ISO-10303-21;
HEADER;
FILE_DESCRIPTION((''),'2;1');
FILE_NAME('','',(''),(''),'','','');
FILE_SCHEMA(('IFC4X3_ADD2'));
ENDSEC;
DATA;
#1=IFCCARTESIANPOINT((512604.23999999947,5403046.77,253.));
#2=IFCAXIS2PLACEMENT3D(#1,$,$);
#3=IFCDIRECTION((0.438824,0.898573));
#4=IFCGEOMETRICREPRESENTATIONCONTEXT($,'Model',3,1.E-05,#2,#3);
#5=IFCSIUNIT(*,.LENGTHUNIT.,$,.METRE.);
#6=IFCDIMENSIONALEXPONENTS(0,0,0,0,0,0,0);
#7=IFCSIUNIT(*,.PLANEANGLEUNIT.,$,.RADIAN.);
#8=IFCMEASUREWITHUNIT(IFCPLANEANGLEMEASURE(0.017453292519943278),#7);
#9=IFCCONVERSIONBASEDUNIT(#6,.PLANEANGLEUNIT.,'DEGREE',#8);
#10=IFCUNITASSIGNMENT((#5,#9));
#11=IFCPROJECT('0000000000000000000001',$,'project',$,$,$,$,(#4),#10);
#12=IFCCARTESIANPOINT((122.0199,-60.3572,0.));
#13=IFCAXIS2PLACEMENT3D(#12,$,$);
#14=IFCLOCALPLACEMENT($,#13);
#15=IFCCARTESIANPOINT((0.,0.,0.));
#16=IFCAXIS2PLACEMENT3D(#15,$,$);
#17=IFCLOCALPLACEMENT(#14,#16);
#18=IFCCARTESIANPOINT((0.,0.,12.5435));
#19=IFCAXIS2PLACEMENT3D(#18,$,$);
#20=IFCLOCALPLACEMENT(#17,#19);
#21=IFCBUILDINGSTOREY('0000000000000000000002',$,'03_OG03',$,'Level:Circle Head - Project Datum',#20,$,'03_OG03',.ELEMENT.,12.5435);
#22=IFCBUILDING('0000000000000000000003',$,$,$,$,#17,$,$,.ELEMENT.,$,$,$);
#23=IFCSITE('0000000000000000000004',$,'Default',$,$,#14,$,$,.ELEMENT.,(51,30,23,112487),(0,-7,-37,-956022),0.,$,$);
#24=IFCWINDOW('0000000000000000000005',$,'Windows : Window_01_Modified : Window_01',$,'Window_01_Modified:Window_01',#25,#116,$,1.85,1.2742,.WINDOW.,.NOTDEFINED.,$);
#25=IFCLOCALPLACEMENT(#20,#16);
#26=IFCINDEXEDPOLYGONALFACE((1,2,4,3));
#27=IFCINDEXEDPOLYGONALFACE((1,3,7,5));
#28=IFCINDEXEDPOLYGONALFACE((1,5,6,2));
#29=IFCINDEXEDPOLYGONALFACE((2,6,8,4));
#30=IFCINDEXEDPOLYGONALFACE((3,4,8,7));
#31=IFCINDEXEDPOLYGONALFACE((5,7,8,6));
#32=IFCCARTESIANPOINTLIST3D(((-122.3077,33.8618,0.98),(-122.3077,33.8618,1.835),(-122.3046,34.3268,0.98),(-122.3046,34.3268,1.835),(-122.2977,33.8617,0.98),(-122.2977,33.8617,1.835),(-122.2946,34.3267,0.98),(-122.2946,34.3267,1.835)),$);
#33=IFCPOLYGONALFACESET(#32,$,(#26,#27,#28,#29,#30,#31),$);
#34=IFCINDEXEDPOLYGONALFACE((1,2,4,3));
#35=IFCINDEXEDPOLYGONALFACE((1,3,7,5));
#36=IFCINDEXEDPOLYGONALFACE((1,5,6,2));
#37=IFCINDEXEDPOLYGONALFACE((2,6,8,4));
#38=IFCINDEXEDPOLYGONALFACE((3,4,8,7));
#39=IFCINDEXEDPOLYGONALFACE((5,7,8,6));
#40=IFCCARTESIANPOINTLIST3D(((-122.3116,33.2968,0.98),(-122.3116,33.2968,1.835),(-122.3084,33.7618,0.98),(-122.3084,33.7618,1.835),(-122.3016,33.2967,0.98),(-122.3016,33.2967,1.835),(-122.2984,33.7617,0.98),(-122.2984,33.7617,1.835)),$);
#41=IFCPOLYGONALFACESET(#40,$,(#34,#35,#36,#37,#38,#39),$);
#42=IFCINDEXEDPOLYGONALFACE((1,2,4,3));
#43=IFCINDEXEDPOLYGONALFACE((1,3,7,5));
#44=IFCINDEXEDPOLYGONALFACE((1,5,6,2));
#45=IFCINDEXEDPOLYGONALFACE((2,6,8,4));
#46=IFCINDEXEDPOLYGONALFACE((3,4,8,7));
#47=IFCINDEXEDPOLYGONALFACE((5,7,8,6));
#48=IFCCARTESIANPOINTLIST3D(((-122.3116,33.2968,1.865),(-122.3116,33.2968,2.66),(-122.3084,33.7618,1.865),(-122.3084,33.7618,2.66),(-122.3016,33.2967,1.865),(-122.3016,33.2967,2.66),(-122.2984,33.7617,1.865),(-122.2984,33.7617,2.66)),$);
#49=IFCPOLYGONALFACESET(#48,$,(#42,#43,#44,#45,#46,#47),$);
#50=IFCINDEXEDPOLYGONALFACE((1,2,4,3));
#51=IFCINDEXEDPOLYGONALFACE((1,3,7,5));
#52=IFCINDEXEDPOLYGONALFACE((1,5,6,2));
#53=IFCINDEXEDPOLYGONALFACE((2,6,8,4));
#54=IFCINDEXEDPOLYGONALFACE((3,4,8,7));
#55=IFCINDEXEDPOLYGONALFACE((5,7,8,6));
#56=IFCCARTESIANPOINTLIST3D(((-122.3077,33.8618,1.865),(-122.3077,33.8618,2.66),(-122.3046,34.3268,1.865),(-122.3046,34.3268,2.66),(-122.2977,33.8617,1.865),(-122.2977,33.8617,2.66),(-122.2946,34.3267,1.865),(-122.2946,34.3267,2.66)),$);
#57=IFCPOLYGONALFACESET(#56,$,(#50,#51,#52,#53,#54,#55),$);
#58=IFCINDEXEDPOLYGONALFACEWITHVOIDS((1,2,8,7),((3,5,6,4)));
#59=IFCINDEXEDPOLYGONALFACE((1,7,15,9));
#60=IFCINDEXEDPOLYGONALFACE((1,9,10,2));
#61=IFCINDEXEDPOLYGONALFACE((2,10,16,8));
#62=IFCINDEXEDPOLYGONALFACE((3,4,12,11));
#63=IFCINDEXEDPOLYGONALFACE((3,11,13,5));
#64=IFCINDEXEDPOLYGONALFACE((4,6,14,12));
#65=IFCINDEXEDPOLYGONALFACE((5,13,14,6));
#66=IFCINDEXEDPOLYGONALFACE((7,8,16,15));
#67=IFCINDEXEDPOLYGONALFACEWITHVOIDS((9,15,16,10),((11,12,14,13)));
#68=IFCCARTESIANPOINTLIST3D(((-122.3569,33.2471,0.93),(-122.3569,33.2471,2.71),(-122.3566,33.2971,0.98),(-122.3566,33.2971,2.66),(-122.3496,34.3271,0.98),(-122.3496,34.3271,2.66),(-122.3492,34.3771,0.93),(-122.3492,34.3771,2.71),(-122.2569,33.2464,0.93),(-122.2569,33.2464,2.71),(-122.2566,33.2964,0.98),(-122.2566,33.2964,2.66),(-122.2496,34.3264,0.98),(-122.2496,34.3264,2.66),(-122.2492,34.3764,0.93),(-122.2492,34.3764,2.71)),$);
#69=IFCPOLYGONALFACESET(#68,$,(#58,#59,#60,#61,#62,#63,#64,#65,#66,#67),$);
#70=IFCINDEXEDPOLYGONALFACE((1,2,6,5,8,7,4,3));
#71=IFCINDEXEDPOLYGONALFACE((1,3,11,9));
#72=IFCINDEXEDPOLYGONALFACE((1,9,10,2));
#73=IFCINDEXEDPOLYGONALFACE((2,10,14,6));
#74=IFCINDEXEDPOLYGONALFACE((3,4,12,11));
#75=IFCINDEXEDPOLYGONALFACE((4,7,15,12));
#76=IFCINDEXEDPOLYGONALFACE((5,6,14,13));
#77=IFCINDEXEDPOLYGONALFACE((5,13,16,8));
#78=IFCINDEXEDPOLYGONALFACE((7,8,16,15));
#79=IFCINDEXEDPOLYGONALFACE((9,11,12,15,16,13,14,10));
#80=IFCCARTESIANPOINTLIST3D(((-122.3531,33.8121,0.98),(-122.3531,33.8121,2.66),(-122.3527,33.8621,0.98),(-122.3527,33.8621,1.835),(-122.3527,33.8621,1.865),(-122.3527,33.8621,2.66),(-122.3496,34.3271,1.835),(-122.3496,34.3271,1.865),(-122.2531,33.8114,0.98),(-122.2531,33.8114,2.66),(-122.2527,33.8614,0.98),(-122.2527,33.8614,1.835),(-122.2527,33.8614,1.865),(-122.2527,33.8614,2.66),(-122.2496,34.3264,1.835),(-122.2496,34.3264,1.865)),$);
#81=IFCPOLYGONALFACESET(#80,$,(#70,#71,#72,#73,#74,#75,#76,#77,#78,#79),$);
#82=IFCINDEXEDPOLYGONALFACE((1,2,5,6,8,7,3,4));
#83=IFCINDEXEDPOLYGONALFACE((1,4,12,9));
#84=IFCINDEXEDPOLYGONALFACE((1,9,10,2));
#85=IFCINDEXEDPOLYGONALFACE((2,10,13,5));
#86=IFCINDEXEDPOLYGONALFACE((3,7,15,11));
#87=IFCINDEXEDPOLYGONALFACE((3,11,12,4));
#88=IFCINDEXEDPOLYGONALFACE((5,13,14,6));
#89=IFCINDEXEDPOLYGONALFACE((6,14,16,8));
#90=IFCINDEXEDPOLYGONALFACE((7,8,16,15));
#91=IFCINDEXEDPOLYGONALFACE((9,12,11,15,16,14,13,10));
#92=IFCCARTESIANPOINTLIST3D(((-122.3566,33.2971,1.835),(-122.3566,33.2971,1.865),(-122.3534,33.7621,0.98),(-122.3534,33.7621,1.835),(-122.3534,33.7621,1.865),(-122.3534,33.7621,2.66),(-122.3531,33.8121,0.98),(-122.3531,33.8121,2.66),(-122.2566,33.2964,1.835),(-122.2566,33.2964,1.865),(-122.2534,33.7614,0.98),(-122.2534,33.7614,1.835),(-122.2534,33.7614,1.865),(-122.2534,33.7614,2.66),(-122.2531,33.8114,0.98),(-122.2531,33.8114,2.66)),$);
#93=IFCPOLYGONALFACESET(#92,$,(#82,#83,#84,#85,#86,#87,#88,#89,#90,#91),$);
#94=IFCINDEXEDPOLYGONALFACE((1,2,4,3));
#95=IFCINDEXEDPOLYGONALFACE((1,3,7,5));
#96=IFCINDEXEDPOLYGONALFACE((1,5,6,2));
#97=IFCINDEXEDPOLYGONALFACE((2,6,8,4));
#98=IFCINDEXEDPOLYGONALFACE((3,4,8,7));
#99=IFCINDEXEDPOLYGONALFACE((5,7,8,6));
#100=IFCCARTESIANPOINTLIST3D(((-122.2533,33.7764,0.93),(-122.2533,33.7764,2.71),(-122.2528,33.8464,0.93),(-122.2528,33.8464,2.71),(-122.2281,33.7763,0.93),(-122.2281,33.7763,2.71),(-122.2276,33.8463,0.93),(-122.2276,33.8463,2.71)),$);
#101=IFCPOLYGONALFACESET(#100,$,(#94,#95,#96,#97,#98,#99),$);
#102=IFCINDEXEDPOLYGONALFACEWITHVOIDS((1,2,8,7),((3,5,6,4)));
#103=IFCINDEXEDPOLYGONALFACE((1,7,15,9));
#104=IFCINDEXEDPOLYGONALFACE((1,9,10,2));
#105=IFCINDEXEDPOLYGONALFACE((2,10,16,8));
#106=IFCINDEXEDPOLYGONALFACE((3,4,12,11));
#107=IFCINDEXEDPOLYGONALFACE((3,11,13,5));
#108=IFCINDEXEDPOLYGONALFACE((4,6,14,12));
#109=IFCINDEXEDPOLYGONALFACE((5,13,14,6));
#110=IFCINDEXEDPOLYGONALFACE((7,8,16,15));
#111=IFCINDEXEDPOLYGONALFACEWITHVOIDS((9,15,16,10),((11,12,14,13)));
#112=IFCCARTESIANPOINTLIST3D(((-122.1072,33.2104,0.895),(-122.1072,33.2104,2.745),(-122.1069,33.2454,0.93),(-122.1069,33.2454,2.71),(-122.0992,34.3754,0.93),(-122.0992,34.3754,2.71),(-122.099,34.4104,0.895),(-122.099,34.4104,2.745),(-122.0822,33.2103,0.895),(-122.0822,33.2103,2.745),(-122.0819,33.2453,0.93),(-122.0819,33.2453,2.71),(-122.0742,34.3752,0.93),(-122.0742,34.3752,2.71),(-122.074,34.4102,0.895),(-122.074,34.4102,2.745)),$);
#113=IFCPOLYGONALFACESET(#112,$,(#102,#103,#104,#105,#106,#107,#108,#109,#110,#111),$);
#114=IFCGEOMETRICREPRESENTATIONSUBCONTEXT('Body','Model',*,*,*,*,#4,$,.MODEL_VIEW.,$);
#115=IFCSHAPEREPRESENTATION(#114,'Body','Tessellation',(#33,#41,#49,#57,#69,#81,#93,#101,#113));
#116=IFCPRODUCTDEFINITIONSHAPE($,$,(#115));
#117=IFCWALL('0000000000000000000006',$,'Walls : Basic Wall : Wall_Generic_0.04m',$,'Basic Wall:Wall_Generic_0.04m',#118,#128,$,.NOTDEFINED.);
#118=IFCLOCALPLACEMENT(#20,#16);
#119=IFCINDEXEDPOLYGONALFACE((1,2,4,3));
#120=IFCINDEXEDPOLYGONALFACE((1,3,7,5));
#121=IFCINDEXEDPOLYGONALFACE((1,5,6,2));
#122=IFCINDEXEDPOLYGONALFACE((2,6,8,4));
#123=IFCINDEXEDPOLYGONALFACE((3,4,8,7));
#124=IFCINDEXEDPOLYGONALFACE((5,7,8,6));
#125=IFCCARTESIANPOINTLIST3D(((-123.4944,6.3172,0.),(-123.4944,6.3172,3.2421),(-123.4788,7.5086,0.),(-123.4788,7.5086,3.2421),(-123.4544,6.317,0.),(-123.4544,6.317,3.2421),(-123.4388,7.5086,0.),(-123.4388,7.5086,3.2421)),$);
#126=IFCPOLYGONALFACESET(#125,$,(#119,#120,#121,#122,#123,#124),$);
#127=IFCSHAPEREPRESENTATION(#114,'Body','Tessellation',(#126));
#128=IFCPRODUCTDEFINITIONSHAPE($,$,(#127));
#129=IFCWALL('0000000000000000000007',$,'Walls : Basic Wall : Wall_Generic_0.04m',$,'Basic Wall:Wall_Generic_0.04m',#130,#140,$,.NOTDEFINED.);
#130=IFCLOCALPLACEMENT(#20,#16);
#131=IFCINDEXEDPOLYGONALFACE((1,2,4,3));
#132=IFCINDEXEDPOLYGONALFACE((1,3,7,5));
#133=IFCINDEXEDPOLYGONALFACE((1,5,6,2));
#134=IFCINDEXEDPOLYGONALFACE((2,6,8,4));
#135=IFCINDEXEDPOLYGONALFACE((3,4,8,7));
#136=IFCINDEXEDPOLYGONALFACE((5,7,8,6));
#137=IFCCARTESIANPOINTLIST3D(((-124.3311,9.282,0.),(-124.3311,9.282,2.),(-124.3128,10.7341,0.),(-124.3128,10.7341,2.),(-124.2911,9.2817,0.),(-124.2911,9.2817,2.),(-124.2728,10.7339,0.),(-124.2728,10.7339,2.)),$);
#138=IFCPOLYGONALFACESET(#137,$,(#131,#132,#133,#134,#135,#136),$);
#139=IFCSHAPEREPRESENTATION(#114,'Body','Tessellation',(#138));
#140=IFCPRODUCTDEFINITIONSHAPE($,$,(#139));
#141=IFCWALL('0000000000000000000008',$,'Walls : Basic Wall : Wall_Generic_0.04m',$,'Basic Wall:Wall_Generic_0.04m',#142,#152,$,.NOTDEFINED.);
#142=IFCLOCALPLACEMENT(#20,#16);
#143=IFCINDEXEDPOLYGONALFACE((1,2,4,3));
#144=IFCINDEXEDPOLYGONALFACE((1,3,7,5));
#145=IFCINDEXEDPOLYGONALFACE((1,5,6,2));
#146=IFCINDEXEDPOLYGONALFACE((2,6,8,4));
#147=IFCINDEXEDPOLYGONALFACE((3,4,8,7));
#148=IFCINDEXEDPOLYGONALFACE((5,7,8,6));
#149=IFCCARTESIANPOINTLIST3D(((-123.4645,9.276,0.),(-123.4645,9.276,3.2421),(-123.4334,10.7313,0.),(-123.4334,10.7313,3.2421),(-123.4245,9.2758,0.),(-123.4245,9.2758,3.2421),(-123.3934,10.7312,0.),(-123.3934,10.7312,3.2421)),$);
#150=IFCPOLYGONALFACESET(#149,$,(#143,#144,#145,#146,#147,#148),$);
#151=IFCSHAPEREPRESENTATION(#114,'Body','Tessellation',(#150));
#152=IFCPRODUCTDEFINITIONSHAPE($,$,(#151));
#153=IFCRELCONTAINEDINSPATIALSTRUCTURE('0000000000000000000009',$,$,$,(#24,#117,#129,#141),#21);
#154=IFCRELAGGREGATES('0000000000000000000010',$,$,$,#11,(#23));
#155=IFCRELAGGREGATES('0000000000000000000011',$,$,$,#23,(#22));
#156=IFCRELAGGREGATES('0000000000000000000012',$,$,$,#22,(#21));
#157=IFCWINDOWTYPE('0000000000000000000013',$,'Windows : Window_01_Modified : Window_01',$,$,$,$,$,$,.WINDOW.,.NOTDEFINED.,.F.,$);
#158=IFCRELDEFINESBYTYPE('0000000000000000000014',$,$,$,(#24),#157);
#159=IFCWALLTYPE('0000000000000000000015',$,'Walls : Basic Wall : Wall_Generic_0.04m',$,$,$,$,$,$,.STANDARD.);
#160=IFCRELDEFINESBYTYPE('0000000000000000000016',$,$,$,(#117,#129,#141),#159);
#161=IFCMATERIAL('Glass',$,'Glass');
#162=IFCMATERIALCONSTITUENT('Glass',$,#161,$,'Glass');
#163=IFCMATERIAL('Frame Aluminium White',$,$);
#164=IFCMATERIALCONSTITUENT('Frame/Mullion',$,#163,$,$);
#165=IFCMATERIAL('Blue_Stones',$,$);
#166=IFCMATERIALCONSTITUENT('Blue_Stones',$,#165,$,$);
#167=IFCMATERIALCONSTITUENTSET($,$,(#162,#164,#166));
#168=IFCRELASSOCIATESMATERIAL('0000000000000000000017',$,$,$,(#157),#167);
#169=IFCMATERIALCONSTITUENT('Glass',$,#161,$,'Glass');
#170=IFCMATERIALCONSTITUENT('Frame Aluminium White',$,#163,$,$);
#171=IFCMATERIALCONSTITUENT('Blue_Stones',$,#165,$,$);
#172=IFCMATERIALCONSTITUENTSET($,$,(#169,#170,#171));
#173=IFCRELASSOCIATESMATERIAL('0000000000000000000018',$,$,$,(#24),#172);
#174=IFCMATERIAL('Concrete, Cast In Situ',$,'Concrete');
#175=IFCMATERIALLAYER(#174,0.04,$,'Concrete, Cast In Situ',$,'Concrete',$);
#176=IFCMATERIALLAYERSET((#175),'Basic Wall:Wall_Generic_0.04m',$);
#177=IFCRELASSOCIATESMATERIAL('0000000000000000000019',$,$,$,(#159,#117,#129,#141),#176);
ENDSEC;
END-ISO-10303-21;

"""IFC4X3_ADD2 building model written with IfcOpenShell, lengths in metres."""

from ifc_helpers import new_model, entity, si_unit, converted_unit, direction, frame, frame_2d, origin, place, context, subcontext, project, spatial, polyline, rectangle, outline, extrude, source, transform, mapped, material, layer, layer_set, constituent, constituent_set, type_object, type_shapes, element, save


model = new_model("IFC4X3_ADD2")

# Units and contexts
model_context = context("Model", 3, precision=1e-05, world=frame((512604.23999999947, 5403046.77, 253.0)), true_north=direction((0.438824, 0.898573)))
body_context = subcontext(model_context, "Body", "Model", "MODEL_VIEW")
ifc_project = project(units=[si_unit("LENGTHUNIT", "METRE"), converted_unit("PLANEANGLEUNIT", "DEGREE", entity("IfcPlaneAngleMeasure", 0.017453292519943278), si_unit("PLANEANGLEUNIT", "RADIAN"), dimensions=[0, 0, 0, 0, 0, 0, 0])], contexts=[model_context])

# Site, building, storey
site_placement = place(None, frame((122.0199, -60.3572, 0.0)))
site = spatial("IfcSite", under=ifc_project, at=site_placement, Name="Default", CompositionType="ELEMENT", RefLatitude=(51, 30, 23, 112487), RefLongitude=(0, -7, -37, -956022), RefElevation=0.0)
building_placement = place(site_placement, origin())
building = spatial("IfcBuilding", under=site, at=building_placement, CompositionType="ELEMENT")
storey_placement = place(building_placement, frame((0.0, 0.0, 12.5435)))
storey = spatial("IfcBuildingStorey", under=building, at=storey_placement, Name="03_OG03", ObjectType="Level:Circle Head - Project Datum", LongName="03_OG03", CompositionType="ELEMENT", Elevation=12.5435)

# Shared definitions
ifc_material_1 = material(Name="Concrete, Cast In Situ", Category="Concrete")

# Window
ifc_material_2 = material(Name="Glass", Category="Glass")
ifc_material_3 = material(Name="Frame Aluminium White")
ifc_material_4 = material(Name="Blue_Stones")
ifc_constituent_1 = constituent(ifc_material_2, Name="Glass", Category="Glass")
ifc_constituent_2 = constituent(ifc_material_3, Name="Frame Aluminium White")
ifc_constituent_3 = constituent(ifc_material_4, Name="Blue_Stones")
ifc_constituent_set_1 = constituent_set(constituents=[ifc_constituent_1, ifc_constituent_2, ifc_constituent_3])
ifc_constituent_4 = constituent(ifc_material_2, Name="Glass", Category="Glass")
ifc_constituent_5 = constituent(ifc_material_3, Name="Frame/Mullion")
ifc_constituent_6 = constituent(ifc_material_4, Name="Blue_Stones")
ifc_constituent_set_2 = constituent_set(constituents=[ifc_constituent_4, ifc_constituent_5, ifc_constituent_6])
window_type_1 = type_object("IfcWindowType", Name="Windows : Window_01_Modified : Window_01", ParameterTakesPrecedence=False, PartitioningType="NOTDEFINED", PredefinedType="WINDOW", material=ifc_constituent_set_2)
shared_shape_1 = source(origin(), body_context, "Body", "SweptSolid", [
    extrude(rectangle(XDim=0.465, YDim=0.01, at=frame_2d((0.0, 0.0), x_axis=(1.0, 0.0))), frame((0.3396, -0.2, 0.0514), z_axis=(0.0, 0.0, 1.0), x_axis=(-1.0, 0.0, 0.0)), (0.0, 0.0, 1.0), 0.855),
    extrude(rectangle(XDim=0.01, YDim=0.465, at=frame_2d((0.0, 0.0), x_axis=(1.0, 0.0))), frame((0.9046, -0.2, 0.0514), z_axis=(0.0, 0.0, 1.0), x_axis=(0.0, 1.0, 0.0)), (0.0, 0.0, 1.0), 0.855),
    extrude(rectangle(XDim=0.465, YDim=0.01, at=frame_2d((0.0, 0.0), x_axis=(1.0, 0.0))), frame((0.9046, -0.2, 0.9364), z_axis=(0.0, 0.0, 1.0), x_axis=(-1.0, 0.0, 0.0)), (0.0, 0.0, 1.0), 0.795),
    extrude(rectangle(XDim=0.465, YDim=0.01, at=frame_2d((0.0, 0.0), x_axis=(1.0, 0.0))), frame((0.3396, -0.2, 0.9364), z_axis=(0.0, 0.0, 1.0), x_axis=(-1.0, 0.0, 0.0)), (0.0, 0.0, 1.0), 0.795),
    extrude(outline(polyline([(-0.89, -0.565), (0.89, -0.565), (0.89, 0.565), (-0.89, 0.565), (-0.89, -0.565)]), holes=[polyline([(0.84, 0.515), (0.84, -0.515), (-0.84, -0.515), (-0.84, 0.515), (0.84, 0.515)])]), frame((0.6221, -0.25, 0.8914), z_axis=(0.0, 1.0, 0.0), x_axis=(0.0, 0.0, 1.0)), (0.0, 0.0, 1.0), 0.1),
    extrude(outline(polyline([(0.03, 0.1037), (0.825, 0.1037), (0.825, 0.1538), (-0.855, 0.1538), (-0.855, 0.1037), (0.0, 0.1037), (0.0, -0.3613), (0.03, -0.3613), (0.03, 0.1037)])), frame((0.4683, -0.25, 0.9064), z_axis=(0.0, 1.0, 0.0), x_axis=(0.0, 0.0, 1.0)), (0.0, 0.0, 1.0), 0.1),
    extrude(outline(polyline([(-0.825, -0.1038), (-0.825, -0.1538), (0.855, -0.1538), (0.855, -0.1038), (0.0, -0.1038), (0.0, 0.3613), (-0.03, 0.3613), (-0.03, -0.1038), (-0.825, -0.1038)])), frame((0.7758, -0.25, 0.9064), z_axis=(0.0, -1.0, 0.0), x_axis=(0.0, 0.0, -1.0)), (0.0, 0.0, -1.0), 0.1),
    extrude(rectangle(XDim=0.0253, YDim=0.07, at=frame_2d((0.0, 0.0), x_axis=(1.0, 0.0))), frame((0.6221, -0.1374, 0.0014), z_axis=(0.0, 0.0, 1.0), x_axis=(0.0, -1.0, 0.0)), (0.0, 0.0, 1.0), 1.78),
    extrude(outline(polyline([(-0.6, -0.925), (0.6, -0.925), (0.6, 0.925), (-0.6, 0.925), (-0.6, -0.925)]), holes=[polyline([(-0.565, -0.89), (-0.565, 0.89), (0.565, 0.89), (0.565, -0.89), (-0.565, -0.89)])]), frame((0.6221, 0.0, 0.8914), z_axis=(0.0, 1.0, 0.0), x_axis=(1.0, 0.0, 0.0)), (0.0, 0.0, 1.0), 0.025),
])
type_shapes(window_type_1, [shared_shape_1])
window_1_placement = place(storey_placement, frame((-122.0989, 34.4325, 0.9286), z_axis=(0.0, 0.0, 1.0), x_axis=(-0.0068, -0.999977, 0.0)))
element("IfcWindow", 1, at=window_1_placement, inside=storey, type_object=window_type_1, material=ifc_constituent_set_1, Name="Windows : Window_01_Modified : Window_01", ObjectType="Window_01_Modified:Window_01", OverallHeight=1.85, OverallWidth=1.2742, PartitioningType="NOTDEFINED", PredefinedType="WINDOW", context=body_context, shape_type="MappedRepresentation", body=[
    mapped(shared_shape_1, transform((0.0, 0.0, 0.0), scale=1.0)),
])

# Walls
ifc_layer_1 = layer(ifc_material_1, 0.04, Name="Concrete, Cast In Situ", Category="Concrete")
ifc_layer_set_1 = layer_set([ifc_layer_1], Name="Basic Wall:Wall_Generic_0.04m")
wall_type_1 = type_object("IfcWallType", Name="Walls : Basic Wall : Wall_Generic_0.04m", PredefinedType="STANDARD", material=ifc_layer_set_1)
wall_1_placement = place(storey_placement, frame((-123.4744, 6.3169, 0.0), z_axis=(0.0, 0.0, 1.0), x_axis=(0.01311, 0.999914, 0.0)))
element("IfcWall", 2, at=wall_1_placement, inside=storey, type_object=wall_type_1, material=ifc_layer_set_1, Name="Walls : Basic Wall : Wall_Generic_0.04m", ObjectType="Basic Wall:Wall_Generic_0.04m", PredefinedType="NOTDEFINED", context=body_context, shape_type="SweptSolid", body=[
    extrude(outline(polyline([(1.192, -0.02), (1.1915, 0.02), (0.0, 0.02), (0.0003, -0.02), (1.192, -0.02)])), origin(), (0.0, 0.0, 1.0), 3.2421),
])
wall_2_placement = place(storey_placement, frame((-124.3111, 9.2817, 0.0), z_axis=(0.0, 0.0, 1.0), x_axis=(0.012644, 0.99992, 0.0)))
element("IfcWall", 3, at=wall_2_placement, inside=storey, type_object=wall_type_1, material=ifc_layer_set_1, Name="Walls : Basic Wall : Wall_Generic_0.04m", ObjectType="Basic Wall:Wall_Generic_0.04m", PredefinedType="NOTDEFINED", context=body_context, shape_type="SweptSolid", body=[
    extrude(outline(polyline([(1.4526, -0.02), (1.4522, 0.02), (0.0, 0.02), (0.0002, -0.02), (1.4526, -0.02)])), origin(), (0.0, 0.0, 1.0), 2.0),
])
wall_3_placement = place(storey_placement, frame((-123.4445, 9.2756, 0.0), z_axis=(0.0, 0.0, 1.0), x_axis=(0.0213, 0.999773, 0.0)))
element("IfcWall", 4, at=wall_3_placement, inside=storey, type_object=wall_type_1, material=ifc_layer_set_1, Name="Walls : Basic Wall : Wall_Generic_0.04m", ObjectType="Basic Wall:Wall_Generic_0.04m", PredefinedType="NOTDEFINED", context=body_context, shape_type="SweptSolid", body=[
    extrude(outline(polyline([(1.4563, -0.02), (1.4556, 0.02), (0.0, 0.02), (0.0006, -0.02), (1.4563, -0.02)])), origin(), (0.0, 0.0, 1.0), 3.2421),
])

save(model, "model.ifc")
